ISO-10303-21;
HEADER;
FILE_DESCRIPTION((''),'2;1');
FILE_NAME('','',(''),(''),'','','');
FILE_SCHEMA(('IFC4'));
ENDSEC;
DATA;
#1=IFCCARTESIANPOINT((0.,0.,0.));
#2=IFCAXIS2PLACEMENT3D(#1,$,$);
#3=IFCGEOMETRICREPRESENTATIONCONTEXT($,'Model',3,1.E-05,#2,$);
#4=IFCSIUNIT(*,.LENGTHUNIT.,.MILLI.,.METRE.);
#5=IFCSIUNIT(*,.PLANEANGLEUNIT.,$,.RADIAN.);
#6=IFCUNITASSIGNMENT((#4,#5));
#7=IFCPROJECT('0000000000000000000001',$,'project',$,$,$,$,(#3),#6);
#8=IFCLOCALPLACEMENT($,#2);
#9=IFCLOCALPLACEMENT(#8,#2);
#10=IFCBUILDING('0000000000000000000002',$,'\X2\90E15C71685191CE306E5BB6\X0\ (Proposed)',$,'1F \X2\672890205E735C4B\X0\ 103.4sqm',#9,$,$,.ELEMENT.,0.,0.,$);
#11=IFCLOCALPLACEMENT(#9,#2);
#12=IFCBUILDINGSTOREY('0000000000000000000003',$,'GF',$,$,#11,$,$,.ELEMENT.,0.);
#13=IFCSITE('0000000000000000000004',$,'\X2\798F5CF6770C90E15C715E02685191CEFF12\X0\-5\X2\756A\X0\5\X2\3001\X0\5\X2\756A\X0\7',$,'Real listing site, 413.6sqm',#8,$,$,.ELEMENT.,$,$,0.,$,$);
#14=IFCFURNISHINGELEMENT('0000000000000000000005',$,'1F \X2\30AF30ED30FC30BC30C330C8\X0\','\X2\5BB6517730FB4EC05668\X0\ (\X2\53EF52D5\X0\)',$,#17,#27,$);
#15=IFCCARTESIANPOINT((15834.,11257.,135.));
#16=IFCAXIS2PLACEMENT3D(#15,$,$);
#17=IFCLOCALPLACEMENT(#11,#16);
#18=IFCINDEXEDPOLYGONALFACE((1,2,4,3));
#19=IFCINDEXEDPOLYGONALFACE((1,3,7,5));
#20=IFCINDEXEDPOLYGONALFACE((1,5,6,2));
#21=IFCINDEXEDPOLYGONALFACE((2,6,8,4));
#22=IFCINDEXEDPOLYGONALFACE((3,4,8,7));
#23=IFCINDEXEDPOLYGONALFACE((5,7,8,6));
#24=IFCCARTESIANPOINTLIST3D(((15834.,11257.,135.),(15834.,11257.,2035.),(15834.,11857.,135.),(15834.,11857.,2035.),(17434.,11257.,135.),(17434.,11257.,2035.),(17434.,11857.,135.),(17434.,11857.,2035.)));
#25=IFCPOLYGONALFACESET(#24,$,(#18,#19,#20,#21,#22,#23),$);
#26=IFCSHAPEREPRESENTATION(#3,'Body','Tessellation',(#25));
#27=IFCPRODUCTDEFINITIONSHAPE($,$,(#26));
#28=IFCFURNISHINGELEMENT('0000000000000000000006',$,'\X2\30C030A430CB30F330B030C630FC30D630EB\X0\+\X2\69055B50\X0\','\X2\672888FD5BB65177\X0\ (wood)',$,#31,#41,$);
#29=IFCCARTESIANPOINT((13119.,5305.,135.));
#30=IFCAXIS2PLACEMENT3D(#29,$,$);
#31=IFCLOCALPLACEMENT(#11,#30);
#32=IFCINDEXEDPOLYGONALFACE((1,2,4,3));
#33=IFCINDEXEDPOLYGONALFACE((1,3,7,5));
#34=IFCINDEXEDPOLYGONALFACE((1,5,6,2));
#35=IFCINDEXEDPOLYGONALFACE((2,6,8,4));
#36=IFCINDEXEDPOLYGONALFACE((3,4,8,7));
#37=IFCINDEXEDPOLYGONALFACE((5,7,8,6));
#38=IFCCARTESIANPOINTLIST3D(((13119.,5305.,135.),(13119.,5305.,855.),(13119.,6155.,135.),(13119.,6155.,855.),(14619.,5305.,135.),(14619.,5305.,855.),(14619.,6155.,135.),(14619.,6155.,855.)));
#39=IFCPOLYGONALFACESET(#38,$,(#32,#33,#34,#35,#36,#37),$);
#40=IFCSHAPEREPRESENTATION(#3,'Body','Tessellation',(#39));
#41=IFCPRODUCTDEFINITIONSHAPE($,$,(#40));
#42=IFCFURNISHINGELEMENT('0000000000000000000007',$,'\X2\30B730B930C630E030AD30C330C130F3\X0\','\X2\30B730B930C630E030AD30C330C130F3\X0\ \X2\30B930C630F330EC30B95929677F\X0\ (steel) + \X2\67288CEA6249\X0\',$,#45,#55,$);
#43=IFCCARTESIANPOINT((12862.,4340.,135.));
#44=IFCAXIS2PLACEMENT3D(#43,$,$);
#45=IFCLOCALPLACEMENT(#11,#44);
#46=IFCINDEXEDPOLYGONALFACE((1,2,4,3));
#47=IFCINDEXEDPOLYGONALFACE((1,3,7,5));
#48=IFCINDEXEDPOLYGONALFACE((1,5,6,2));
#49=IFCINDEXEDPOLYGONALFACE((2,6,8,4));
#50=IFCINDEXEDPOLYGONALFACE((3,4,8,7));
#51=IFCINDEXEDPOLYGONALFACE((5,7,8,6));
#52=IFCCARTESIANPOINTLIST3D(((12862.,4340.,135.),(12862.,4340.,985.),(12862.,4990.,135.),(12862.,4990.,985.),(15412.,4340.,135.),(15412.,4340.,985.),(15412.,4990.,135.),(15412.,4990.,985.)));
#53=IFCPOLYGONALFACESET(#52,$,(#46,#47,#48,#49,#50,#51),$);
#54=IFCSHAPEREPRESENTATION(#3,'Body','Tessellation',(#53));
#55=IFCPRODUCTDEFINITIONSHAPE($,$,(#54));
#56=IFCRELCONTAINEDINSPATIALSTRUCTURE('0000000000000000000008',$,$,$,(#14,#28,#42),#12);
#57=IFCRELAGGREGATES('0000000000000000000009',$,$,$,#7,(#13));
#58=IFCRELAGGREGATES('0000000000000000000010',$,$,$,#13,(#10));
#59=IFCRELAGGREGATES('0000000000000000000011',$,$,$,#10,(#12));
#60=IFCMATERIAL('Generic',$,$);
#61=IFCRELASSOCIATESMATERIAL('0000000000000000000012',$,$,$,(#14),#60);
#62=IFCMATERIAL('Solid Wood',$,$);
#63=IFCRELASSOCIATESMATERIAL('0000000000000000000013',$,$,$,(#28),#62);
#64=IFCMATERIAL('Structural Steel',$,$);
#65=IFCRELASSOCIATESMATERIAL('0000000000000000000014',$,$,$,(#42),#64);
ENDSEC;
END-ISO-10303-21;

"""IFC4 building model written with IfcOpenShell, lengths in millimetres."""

from ifc_helpers import new_model, si_unit, frame, frame_2d, origin, place, context, project, spatial, rectangle, extrude, material, element, save


model = new_model("IFC4")

# Units and contexts
model_context = context("Model", 3, precision=1e-05, world=origin())
ifc_project = project(units=[si_unit("LENGTHUNIT", "METRE", prefix="MILLI"), si_unit("PLANEANGLEUNIT", "RADIAN")], contexts=[model_context])

# Site, building, storey
site_placement = place(None, origin())
site = spatial("IfcSite", under=ifc_project, at=site_placement, Name="福島県郡山市桑野２-5番5、5番7", ObjectType="Real listing site, 413.6sqm", CompositionType="ELEMENT", RefElevation=0.0)
building_placement = place(site_placement, origin())
building = spatial("IfcBuilding", under=site, at=building_placement, Name="郡山桑野の家 (Proposed)", ObjectType="1F 木造平屋 103.4sqm", CompositionType="ELEMENT", ElevationOfRefHeight=0.0, ElevationOfTerrain=0.0)
storey_placement = place(building_placement, origin())
storey = spatial("IfcBuildingStorey", under=building, at=storey_placement, Name="GF", CompositionType="ELEMENT", Elevation=0.0)

# Shared definitions
ifc_material_1 = material(Name="Solid Wood")

# Shared definitions
ifc_material_2 = material(Name="Structural Steel")

# Shared definitions
ifc_material_3 = material(Name="Generic")

# Furnishing elements
furnishing_1_placement = place(storey_placement, frame((15834.0, 11257.0, 135.0)))
element("IfcFurnishingElement", 1, at=furnishing_1_placement, inside=storey, material=ifc_material_3, Name="1F クローゼット", Description="家具・什器 (可動)", context=model_context, shape_type="SweptSolid", body=[
    extrude(rectangle(XDim=1600.0, YDim=600.0, at=frame_2d((800.0, 300.0))), frame((15834.0, 11257.0, 135.0)), (0.0, 0.0, 1.0), 1900.0),
])
furnishing_2_placement = place(storey_placement, frame((13119.0, 5305.0, 135.0)))
element("IfcFurnishingElement", 2, at=furnishing_2_placement, inside=storey, material=ifc_material_1, Name="ダイニングテーブル+椅子", Description="木製家具 (wood)", context=model_context, shape_type="SweptSolid", body=[
    extrude(rectangle(XDim=1500.0, YDim=850.0, at=frame_2d((750.0, 425.0))), frame((13119.0, 5305.0, 135.0)), (0.0, 0.0, 1.0), 720.0),
])
furnishing_3_placement = place(storey_placement, frame((12862.0, 4340.0, 135.0)))
element("IfcFurnishingElement", 3, at=furnishing_3_placement, inside=storey, material=ifc_material_2, Name="システムキッチン", Description="システムキッチン ステンレス天板 (steel) + 木質扉", context=model_context, shape_type="SweptSolid", body=[
    extrude(rectangle(XDim=2550.0, YDim=650.0, at=frame_2d((1275.0, 325.0))), frame((12862.0, 4340.0, 135.0)), (0.0, 0.0, 1.0), 850.0),
])

save(model, "model.ifc")
